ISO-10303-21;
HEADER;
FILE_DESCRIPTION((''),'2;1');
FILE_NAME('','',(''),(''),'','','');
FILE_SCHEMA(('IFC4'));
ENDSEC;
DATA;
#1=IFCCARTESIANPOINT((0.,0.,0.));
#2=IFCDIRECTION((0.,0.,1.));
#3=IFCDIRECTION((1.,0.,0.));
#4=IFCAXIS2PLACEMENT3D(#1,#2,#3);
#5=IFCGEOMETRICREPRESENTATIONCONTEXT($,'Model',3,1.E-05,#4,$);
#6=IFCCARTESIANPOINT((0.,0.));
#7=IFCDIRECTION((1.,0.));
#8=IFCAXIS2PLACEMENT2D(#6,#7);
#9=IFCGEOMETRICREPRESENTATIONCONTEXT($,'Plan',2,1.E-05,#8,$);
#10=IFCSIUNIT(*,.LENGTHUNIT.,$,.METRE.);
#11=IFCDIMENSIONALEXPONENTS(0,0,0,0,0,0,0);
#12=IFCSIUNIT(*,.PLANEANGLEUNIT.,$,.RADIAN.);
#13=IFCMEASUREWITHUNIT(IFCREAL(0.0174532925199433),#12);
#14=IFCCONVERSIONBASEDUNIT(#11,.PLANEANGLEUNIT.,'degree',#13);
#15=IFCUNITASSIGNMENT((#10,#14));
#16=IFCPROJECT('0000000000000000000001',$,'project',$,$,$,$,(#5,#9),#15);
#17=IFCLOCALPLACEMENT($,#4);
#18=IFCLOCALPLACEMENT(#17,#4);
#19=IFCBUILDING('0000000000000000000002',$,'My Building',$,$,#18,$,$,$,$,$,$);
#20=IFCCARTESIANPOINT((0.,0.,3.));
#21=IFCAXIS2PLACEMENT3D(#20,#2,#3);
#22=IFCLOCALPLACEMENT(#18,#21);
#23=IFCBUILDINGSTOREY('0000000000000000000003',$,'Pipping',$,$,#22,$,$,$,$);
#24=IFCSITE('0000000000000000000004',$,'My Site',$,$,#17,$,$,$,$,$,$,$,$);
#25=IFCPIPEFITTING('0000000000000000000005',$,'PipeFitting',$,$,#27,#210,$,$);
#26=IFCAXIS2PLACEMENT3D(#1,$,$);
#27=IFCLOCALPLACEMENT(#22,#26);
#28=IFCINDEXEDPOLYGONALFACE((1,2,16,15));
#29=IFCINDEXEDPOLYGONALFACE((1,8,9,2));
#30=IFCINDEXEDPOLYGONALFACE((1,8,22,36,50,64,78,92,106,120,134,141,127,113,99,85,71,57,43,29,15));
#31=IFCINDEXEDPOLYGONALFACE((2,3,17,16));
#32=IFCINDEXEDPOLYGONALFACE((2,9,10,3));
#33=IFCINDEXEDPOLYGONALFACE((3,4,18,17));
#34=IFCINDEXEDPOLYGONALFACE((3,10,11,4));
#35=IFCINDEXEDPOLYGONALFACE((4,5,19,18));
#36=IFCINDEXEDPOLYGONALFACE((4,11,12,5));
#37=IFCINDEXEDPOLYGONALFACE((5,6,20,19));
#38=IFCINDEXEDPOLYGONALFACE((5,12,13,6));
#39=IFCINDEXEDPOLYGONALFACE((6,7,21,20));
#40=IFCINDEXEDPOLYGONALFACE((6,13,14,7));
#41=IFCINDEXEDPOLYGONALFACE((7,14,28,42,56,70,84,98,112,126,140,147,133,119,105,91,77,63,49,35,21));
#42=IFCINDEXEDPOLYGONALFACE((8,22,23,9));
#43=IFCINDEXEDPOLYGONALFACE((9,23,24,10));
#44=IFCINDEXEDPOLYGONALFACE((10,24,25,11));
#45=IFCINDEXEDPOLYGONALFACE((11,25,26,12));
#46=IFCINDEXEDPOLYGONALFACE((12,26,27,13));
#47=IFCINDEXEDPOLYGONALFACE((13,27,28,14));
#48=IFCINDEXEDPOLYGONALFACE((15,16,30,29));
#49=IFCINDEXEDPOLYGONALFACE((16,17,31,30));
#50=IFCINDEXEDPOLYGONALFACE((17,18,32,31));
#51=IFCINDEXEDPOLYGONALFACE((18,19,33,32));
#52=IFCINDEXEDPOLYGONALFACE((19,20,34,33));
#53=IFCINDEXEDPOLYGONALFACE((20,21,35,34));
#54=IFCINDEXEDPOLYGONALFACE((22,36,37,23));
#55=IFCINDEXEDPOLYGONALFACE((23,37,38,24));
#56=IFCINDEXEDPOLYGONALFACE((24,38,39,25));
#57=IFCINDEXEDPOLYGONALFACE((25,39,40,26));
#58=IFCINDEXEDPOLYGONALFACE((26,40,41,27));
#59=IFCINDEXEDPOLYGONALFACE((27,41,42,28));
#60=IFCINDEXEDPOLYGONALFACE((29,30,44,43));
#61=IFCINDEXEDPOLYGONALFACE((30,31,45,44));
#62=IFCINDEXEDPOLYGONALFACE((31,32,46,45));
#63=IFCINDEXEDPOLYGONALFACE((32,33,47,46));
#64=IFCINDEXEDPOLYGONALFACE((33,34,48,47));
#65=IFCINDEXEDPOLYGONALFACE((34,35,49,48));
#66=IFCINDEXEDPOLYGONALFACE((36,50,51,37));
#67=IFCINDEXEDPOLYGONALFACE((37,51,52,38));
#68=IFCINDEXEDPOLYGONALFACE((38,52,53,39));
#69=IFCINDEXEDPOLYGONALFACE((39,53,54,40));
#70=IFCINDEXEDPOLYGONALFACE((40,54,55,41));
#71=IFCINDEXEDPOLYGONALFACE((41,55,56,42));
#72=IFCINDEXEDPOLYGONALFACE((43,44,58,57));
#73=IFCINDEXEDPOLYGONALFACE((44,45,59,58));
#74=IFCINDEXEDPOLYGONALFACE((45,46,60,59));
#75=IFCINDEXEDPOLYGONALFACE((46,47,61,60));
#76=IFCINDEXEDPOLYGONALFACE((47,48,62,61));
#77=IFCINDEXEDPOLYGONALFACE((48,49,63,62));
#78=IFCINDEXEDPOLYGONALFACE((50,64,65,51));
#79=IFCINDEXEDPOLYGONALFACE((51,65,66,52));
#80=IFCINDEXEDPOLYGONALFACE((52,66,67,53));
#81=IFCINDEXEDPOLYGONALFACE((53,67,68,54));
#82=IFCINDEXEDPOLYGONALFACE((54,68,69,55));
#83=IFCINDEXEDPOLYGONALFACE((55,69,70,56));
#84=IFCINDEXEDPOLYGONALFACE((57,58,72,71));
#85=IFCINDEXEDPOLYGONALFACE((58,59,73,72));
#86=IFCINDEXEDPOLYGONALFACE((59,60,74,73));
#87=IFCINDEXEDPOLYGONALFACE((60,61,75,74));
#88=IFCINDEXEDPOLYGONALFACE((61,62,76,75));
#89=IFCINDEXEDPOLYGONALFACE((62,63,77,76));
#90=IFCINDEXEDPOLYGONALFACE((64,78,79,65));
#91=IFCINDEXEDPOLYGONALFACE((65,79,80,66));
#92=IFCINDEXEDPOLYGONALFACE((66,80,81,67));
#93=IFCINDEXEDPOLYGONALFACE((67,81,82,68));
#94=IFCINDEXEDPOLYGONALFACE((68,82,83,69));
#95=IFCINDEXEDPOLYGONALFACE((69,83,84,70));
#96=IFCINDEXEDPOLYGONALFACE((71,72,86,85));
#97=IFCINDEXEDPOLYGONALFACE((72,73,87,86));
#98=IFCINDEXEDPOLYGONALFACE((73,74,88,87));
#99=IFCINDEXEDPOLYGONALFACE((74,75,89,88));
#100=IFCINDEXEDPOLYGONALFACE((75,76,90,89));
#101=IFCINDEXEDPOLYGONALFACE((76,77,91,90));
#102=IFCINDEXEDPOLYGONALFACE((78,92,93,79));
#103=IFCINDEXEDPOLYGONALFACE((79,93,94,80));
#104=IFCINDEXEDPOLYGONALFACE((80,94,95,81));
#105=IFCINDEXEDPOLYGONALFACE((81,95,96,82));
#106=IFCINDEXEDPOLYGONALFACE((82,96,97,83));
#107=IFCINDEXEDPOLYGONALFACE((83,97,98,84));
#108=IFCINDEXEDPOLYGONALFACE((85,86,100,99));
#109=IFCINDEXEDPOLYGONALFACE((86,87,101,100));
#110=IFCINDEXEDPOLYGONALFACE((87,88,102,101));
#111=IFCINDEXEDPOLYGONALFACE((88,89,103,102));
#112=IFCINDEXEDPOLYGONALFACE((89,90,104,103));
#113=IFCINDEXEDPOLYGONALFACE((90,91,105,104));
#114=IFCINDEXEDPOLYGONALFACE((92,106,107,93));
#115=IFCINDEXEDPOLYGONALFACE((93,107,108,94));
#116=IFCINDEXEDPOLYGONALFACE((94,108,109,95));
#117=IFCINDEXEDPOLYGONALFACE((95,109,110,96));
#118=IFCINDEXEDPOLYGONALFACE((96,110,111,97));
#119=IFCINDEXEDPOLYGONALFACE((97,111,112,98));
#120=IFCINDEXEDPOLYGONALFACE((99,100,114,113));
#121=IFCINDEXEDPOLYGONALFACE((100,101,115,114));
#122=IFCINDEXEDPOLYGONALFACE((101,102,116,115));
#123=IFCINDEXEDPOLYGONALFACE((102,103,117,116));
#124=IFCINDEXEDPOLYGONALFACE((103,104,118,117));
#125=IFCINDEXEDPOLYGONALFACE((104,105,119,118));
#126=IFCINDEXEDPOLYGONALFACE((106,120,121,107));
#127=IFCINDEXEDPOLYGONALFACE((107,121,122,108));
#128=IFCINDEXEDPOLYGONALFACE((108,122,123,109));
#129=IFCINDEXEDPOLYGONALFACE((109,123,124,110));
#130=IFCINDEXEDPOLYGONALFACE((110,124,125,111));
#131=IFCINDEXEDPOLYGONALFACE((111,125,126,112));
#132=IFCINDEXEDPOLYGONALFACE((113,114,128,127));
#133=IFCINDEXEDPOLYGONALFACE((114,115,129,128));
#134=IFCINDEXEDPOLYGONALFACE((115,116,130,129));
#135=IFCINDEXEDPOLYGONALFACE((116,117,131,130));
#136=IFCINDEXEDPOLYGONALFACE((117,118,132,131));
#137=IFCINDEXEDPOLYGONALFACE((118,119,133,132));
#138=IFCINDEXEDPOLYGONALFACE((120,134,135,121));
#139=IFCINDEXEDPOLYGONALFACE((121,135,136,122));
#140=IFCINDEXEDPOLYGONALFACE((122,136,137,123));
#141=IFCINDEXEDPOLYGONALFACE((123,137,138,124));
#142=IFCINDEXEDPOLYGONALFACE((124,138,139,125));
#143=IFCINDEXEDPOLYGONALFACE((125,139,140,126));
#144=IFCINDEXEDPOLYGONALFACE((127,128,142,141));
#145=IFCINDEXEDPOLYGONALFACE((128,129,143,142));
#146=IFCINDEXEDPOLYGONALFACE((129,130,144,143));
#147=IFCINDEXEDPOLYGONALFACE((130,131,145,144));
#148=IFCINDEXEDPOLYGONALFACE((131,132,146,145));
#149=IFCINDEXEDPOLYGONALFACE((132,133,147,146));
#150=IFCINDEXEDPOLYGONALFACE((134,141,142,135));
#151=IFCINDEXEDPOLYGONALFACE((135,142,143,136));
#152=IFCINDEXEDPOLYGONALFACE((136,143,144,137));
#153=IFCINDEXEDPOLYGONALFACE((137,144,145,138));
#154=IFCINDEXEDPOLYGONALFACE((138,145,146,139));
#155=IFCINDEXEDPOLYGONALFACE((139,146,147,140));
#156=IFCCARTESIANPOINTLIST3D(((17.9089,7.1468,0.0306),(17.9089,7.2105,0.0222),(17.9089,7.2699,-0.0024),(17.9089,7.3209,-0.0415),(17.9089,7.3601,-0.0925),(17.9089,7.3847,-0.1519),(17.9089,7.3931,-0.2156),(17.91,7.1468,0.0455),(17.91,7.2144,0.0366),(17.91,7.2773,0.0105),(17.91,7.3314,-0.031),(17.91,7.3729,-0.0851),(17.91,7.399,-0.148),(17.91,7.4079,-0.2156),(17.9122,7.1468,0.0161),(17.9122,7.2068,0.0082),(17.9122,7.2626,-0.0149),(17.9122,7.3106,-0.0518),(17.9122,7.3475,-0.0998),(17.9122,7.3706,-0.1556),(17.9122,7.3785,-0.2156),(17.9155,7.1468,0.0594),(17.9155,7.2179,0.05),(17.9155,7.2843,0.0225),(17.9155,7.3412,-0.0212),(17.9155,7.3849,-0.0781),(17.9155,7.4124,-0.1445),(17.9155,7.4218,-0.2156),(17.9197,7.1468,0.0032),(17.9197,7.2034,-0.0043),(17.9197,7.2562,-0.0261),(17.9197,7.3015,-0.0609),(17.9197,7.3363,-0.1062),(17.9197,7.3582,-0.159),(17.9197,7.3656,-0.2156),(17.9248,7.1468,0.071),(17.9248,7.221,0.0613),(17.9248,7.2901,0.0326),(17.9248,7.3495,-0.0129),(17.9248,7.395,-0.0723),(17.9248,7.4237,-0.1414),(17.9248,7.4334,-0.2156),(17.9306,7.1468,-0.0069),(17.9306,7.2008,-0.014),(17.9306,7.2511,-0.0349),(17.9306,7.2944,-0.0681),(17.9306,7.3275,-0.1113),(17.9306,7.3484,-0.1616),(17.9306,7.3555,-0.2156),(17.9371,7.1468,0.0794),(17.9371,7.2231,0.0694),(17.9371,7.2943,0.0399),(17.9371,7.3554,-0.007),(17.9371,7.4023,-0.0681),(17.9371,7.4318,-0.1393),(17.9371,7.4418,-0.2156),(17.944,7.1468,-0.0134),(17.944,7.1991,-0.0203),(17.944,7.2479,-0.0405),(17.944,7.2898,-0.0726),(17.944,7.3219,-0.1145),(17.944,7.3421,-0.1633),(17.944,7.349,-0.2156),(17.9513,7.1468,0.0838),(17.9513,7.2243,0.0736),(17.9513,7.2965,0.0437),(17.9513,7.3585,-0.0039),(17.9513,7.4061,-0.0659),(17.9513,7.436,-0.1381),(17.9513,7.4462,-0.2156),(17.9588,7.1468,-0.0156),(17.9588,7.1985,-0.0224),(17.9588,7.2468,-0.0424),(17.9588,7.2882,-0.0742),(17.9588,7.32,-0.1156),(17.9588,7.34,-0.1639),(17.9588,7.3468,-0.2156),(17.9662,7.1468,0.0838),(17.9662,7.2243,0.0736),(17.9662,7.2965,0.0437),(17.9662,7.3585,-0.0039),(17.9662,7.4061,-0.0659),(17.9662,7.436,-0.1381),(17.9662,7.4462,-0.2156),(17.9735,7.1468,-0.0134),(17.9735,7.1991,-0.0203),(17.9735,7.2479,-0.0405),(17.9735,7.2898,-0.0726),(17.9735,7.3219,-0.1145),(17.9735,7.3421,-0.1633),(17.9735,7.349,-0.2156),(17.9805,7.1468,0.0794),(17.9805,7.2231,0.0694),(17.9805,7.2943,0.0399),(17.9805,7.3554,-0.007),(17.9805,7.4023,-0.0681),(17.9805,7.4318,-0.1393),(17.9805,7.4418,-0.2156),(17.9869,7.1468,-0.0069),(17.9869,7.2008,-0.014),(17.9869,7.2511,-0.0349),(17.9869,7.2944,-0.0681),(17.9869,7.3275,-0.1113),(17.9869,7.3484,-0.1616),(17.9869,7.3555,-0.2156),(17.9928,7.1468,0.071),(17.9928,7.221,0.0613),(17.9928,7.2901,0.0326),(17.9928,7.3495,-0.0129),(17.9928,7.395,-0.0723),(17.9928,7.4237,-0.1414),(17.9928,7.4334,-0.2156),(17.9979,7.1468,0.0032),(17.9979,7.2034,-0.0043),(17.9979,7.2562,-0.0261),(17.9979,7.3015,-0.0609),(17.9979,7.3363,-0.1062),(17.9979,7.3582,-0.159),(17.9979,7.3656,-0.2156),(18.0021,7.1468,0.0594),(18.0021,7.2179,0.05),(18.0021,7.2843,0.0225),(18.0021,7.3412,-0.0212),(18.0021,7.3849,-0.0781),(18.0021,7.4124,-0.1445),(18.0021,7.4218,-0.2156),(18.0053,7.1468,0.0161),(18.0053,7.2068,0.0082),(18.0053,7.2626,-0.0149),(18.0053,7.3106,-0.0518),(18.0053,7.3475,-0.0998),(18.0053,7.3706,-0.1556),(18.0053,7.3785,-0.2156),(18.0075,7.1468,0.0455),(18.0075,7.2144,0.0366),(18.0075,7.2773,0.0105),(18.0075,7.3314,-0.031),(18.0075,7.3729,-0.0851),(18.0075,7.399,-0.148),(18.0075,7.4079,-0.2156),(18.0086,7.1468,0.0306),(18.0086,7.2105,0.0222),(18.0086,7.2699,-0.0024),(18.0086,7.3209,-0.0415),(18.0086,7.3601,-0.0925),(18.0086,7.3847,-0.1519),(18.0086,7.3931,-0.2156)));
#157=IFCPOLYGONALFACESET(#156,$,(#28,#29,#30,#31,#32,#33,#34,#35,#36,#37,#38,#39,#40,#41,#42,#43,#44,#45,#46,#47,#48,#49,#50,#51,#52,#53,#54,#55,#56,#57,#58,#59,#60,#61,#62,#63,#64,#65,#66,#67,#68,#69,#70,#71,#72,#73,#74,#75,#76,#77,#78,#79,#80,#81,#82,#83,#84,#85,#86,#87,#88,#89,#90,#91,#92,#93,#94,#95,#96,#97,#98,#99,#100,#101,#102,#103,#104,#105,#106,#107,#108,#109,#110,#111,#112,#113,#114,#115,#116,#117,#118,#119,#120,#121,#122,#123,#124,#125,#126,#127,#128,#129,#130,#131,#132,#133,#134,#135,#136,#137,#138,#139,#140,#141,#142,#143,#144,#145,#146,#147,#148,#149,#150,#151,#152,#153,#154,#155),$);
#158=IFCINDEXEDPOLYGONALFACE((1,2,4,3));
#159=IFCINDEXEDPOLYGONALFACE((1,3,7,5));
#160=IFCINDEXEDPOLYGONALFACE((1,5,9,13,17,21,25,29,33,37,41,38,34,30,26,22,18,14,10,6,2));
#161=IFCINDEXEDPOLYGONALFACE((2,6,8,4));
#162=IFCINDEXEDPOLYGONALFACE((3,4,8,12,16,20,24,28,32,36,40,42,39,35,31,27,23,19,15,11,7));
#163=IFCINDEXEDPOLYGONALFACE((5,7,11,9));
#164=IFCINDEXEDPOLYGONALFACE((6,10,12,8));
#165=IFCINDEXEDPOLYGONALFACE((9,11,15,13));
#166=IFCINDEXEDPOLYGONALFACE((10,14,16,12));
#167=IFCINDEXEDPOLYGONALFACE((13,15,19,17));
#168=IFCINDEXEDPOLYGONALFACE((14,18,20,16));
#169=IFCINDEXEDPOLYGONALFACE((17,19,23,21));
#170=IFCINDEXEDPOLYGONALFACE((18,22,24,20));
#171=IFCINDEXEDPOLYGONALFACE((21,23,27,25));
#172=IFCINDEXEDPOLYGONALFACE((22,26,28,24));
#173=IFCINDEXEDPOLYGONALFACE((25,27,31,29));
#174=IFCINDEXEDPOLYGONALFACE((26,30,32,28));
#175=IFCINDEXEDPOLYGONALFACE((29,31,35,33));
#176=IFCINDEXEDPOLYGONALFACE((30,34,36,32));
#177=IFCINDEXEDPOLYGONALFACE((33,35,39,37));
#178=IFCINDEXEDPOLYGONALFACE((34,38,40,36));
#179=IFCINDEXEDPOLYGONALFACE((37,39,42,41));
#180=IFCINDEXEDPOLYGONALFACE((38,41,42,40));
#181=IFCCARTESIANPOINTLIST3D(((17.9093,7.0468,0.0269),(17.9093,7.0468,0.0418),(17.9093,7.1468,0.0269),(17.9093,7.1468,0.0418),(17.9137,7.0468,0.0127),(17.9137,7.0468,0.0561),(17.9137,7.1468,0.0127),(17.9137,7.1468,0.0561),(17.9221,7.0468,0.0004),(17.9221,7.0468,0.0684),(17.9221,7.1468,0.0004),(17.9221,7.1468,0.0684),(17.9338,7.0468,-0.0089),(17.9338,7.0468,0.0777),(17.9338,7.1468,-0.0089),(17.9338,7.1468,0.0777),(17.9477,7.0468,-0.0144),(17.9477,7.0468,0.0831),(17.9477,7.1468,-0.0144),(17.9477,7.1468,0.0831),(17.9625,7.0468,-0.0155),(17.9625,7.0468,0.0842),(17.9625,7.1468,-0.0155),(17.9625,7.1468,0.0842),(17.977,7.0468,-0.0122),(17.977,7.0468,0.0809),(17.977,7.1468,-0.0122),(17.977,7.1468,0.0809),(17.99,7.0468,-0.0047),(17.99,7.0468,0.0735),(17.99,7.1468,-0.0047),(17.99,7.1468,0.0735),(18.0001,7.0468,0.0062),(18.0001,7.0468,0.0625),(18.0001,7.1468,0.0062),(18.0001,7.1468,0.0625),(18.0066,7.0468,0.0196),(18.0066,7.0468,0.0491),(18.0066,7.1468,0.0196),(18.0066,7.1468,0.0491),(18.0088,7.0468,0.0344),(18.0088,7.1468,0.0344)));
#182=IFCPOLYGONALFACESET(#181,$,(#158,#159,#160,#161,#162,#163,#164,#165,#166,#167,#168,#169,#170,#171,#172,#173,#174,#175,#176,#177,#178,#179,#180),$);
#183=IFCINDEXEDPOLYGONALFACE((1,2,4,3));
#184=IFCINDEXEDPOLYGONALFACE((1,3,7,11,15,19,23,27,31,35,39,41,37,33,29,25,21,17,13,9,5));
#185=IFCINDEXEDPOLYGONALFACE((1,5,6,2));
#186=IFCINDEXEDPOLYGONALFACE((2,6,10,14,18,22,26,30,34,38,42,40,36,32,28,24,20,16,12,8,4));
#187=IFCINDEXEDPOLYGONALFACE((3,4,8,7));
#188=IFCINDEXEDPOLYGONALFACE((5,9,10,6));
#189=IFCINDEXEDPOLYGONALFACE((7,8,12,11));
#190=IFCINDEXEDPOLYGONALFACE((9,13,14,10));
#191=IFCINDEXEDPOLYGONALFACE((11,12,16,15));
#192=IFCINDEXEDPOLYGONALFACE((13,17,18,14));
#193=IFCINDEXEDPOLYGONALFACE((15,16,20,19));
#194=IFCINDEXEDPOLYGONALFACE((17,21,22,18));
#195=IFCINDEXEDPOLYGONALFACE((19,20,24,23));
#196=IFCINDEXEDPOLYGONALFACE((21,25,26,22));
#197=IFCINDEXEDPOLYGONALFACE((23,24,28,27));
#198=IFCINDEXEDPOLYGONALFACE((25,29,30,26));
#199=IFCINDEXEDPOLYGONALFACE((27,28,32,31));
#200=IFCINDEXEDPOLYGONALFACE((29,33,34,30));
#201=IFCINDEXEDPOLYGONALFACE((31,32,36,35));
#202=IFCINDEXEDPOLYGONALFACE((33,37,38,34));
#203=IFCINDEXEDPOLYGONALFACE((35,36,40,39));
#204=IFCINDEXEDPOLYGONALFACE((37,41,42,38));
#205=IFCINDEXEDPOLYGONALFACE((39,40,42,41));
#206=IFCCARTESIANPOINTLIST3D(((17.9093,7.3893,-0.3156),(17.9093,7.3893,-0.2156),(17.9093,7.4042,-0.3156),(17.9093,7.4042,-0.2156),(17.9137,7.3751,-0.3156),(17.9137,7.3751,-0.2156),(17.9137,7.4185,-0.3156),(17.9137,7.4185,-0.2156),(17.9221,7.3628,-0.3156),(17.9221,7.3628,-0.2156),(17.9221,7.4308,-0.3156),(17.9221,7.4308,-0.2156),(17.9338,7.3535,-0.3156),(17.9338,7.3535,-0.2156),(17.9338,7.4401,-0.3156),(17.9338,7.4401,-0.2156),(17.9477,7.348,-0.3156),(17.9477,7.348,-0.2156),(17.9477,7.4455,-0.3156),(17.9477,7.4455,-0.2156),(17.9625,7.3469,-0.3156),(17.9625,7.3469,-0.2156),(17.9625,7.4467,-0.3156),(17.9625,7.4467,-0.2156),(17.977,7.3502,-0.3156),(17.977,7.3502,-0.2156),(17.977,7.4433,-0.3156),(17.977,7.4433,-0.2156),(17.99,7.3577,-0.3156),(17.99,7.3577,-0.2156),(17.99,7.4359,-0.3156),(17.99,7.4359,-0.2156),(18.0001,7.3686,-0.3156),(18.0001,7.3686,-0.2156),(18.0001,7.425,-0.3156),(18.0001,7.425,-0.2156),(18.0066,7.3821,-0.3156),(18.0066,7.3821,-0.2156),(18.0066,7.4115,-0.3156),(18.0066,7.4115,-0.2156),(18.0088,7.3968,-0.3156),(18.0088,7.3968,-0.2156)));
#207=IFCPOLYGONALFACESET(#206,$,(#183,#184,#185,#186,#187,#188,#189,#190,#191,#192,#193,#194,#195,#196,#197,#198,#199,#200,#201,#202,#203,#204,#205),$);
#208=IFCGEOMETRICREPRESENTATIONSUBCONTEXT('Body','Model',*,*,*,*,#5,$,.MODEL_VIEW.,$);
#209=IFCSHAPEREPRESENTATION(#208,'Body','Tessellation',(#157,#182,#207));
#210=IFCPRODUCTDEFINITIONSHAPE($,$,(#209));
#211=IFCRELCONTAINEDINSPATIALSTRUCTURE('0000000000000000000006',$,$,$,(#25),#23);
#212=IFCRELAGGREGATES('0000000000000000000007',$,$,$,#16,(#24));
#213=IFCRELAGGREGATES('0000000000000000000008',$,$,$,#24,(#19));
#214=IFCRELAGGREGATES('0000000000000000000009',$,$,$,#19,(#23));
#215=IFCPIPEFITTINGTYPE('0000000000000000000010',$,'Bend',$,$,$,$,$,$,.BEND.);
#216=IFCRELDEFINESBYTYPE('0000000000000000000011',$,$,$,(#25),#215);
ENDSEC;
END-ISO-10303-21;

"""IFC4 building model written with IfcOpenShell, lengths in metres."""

from ifc_helpers import new_model, entity, si_unit, converted_unit, frame, origin_with_axes, origin_2d_with_axis, place, context, subcontext, project, spatial, circle, extrude, source, transform, mapped, type_object, type_shapes, element, save


model = new_model("IFC4")

# Units and contexts
model_context = context("Model", 3, precision=1e-05, world=origin_with_axes())
plan_context = context("Plan", 2, precision=1e-05, world=origin_2d_with_axis())
body_context = subcontext(model_context, "Body", "Model", "MODEL_VIEW")
ifc_project = project(units=[si_unit("LENGTHUNIT", "METRE"), converted_unit("PLANEANGLEUNIT", "degree", entity("IfcReal", 0.0174532925199433), si_unit("PLANEANGLEUNIT", "RADIAN"), dimensions=[0, 0, 0, 0, 0, 0, 0])], contexts=[model_context, plan_context])

# Site, building, storey
site_placement = place(None, origin_with_axes())
site = spatial("IfcSite", under=ifc_project, at=site_placement, Name="My Site")
building_placement = place(site_placement, origin_with_axes())
building = spatial("IfcBuilding", under=site, at=building_placement, Name="My Building")
storey_placement = place(building_placement, frame((0.0, 0.0, 3.0), z_axis=(0.0, 0.0, 1.0), x_axis=(1.0, 0.0, 0.0)))
storey = spatial("IfcBuildingStorey", under=building, at=storey_placement, Name="Pipping")

# Pipe fitting
pipe_fitting_type_1 = type_object("IfcPipeFittingType", Name="Bend", PredefinedType="BEND")
shared_shape_1 = source(origin_with_axes(), body_context, "Body", "SolidModel", [
    entity("IfcSweptDiskSolid", entity("IfcIndexedPolyCurve", entity("IfcCartesianPointList3D", [[0.0, 0.0, 0.1], [0.0, 0.0732, 0.2768], [0.0, 0.25, 0.35]]), [entity("IfcArcIndex", [1, 2, 3])]), 0.05),
    extrude(circle(Radius=0.05), origin_with_axes(), (0.0, 0.0, 1.0), 0.1),
    extrude(circle(Radius=0.05), frame((0.0, 0.25, 0.35), z_axis=(0.0, 1.0, -0.000073), x_axis=(1.0, 0.0, 0.0)), (0.0, 0.0, 1.0), 0.1),
])
type_shapes(pipe_fitting_type_1, [shared_shape_1])
for number, where, z_axis, x_axis, name in (
    (1, (17.9588, 7.0468, 0.0344), (0.0, 1.0, 0.000073), (1.0, 0.0, 0.0), "PipeFitting"),
):
    element("IfcPipeFitting", number, at=place(storey_placement, frame(where, z_axis=z_axis, x_axis=x_axis)), inside=storey, type_object=pipe_fitting_type_1, Name=name, context=body_context, shape_type="MappedRepresentation", body=[
        mapped(shared_shape_1, transform((0.0, 0.0, 0.0), x_axis=(1.0, 0.0, 0.0), y_axis=(0.0, 1.0, 0.0), z_axis=(0.0, 0.0, 1.0), scale=1.0)),
    ])

save(model, "model.ifc")
